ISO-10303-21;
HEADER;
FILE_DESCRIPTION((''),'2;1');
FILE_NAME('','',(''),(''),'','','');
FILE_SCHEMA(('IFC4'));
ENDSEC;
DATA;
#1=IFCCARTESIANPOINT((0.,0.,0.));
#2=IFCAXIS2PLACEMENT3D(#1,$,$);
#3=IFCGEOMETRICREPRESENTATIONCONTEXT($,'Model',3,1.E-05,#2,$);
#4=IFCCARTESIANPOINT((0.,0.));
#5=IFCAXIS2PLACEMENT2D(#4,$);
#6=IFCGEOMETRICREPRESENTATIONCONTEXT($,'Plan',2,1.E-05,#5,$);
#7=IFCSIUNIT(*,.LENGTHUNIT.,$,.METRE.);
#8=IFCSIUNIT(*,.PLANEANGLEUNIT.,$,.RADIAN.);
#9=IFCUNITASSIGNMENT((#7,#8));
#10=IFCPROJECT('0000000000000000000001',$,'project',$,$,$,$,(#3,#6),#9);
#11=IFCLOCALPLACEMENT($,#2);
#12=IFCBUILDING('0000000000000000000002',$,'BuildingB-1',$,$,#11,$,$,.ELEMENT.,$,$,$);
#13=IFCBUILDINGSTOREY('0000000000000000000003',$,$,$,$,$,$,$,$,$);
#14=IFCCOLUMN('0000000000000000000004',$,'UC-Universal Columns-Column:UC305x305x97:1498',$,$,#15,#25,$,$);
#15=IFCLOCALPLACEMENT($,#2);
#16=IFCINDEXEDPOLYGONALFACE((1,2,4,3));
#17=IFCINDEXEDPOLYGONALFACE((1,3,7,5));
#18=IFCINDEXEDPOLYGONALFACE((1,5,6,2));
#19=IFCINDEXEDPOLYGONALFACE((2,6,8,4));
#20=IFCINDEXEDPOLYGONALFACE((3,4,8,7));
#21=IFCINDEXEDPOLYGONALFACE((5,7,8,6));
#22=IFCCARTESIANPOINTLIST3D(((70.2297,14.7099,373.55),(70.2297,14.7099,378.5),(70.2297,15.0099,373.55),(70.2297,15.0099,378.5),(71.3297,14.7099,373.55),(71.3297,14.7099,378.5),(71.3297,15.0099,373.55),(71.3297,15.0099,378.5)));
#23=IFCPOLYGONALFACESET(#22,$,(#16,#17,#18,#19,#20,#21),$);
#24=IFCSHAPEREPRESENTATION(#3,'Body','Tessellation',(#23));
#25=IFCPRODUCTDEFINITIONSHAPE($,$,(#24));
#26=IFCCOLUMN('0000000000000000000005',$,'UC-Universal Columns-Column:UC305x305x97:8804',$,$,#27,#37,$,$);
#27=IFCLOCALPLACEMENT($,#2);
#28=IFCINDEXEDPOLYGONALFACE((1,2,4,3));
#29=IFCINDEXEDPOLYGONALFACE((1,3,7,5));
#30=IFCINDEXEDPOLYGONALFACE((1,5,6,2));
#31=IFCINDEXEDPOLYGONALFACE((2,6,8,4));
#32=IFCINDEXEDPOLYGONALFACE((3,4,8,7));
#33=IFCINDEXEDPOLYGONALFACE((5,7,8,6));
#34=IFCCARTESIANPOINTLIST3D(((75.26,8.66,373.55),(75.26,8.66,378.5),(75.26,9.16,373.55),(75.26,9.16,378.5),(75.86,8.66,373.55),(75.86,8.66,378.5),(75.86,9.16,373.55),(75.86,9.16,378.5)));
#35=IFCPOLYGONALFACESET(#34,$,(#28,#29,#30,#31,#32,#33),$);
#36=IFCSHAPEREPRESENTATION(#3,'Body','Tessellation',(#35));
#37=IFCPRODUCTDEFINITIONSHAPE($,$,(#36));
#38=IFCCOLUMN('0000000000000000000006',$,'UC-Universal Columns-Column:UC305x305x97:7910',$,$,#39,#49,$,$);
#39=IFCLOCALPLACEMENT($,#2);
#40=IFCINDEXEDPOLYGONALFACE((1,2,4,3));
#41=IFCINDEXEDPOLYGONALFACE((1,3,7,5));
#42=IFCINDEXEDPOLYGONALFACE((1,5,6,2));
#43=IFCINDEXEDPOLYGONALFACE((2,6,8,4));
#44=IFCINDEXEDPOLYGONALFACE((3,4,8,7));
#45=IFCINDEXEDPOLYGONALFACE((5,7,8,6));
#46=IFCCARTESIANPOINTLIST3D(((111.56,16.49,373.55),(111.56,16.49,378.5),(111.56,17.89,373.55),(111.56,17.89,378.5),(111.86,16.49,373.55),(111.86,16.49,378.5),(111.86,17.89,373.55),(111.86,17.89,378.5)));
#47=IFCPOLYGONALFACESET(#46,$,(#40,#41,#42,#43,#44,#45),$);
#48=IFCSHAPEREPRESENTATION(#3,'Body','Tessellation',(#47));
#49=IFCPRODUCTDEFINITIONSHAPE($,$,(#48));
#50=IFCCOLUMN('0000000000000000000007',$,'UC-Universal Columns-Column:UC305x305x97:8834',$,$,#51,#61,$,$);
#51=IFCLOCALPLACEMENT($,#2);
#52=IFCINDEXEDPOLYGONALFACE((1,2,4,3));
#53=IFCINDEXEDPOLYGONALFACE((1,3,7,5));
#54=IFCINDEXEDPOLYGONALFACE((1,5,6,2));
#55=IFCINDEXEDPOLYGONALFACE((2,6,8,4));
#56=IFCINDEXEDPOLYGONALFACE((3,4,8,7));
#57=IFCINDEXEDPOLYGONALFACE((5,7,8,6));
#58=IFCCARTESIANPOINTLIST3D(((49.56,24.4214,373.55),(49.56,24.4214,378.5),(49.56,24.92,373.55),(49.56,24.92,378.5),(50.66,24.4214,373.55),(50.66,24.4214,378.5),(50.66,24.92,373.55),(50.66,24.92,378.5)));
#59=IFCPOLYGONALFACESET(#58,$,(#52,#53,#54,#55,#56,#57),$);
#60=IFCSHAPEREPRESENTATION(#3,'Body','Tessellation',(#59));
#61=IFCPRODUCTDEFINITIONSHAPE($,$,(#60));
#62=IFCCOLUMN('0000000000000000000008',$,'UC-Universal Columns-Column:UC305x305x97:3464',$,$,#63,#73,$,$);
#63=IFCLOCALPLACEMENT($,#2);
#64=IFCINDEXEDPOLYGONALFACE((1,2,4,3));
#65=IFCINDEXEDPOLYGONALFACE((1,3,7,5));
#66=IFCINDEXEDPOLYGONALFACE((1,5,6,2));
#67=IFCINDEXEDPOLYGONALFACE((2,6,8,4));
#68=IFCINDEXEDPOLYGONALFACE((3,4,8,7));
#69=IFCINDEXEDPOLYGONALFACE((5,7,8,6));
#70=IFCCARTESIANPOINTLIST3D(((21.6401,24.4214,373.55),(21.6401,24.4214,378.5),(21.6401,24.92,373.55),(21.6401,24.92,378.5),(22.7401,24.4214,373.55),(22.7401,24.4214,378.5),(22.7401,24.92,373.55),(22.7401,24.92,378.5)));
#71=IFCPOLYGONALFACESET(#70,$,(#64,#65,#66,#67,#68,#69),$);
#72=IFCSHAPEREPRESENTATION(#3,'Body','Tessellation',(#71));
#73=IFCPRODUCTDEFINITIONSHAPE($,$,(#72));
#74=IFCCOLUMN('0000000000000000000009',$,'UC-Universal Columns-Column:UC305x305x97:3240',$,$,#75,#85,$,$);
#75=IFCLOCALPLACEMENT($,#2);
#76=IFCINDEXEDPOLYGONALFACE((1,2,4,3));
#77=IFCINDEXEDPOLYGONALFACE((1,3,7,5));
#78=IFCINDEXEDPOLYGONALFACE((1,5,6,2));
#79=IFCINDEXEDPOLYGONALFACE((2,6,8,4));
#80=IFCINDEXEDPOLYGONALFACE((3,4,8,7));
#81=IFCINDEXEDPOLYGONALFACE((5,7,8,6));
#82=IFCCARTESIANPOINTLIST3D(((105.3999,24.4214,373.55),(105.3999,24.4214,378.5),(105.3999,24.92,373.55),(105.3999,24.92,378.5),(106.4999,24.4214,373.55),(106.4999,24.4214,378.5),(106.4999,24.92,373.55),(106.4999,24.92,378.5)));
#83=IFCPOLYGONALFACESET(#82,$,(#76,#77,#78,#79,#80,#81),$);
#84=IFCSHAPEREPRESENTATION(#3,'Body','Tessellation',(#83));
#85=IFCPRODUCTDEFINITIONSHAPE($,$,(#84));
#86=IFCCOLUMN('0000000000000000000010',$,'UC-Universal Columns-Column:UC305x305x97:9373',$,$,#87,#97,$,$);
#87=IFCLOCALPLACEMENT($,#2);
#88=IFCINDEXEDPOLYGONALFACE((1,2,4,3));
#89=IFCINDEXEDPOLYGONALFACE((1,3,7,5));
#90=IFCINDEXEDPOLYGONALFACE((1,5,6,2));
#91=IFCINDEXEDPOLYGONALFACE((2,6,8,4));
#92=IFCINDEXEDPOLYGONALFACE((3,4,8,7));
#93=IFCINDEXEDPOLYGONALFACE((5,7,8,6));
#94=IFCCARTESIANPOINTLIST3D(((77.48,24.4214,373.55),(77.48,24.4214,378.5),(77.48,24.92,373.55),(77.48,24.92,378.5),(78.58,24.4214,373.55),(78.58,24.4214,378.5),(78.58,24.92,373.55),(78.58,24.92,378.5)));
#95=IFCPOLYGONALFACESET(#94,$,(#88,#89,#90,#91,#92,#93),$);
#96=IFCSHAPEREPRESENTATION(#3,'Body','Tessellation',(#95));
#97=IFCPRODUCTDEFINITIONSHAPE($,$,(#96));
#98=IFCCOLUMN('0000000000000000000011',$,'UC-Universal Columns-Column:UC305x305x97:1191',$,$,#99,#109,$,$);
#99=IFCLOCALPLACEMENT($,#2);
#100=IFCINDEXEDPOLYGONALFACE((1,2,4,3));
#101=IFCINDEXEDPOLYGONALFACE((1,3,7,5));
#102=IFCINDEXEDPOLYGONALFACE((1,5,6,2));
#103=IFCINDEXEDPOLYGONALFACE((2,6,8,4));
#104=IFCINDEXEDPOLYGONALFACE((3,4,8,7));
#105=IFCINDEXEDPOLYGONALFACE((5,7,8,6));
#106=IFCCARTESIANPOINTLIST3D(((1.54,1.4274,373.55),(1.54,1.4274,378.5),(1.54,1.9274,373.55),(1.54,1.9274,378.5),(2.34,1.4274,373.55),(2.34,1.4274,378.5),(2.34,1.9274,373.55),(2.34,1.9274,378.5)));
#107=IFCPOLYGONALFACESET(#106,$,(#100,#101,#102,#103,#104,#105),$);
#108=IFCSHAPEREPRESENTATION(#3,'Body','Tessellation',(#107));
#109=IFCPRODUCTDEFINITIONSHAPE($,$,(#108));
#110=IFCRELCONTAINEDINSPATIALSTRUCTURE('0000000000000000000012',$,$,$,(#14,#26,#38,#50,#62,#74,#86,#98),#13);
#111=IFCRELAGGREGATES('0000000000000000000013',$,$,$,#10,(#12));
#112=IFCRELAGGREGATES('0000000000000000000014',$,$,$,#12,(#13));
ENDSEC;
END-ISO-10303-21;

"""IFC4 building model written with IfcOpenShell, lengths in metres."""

from ifc_helpers import new_model, si_unit, origin, origin_2d, place, context, project, spatial, polyline, outline, extrude, element, save


model = new_model("IFC4")

# Units and contexts
model_context = context("Model", 3, precision=1e-05, world=origin())
plan_context = context("Plan", 2, precision=1e-05, world=origin_2d())
ifc_project = project(units=[si_unit("LENGTHUNIT", "METRE"), si_unit("PLANEANGLEUNIT", "RADIAN")], contexts=[model_context, plan_context])

# Building, storey
building_placement = place(None, origin())
building = spatial("IfcBuilding", under=ifc_project, at=building_placement, Name="BuildingB-1", CompositionType="ELEMENT")
storey = spatial("IfcBuildingStorey", under=building)

# Columns
element("IfcColumn", 1, inside=storey, Name="UC-Universal Columns-Column:UC305x305x97:1498", context=model_context, shape_type="SweptSolid", body=[
    extrude(outline(polyline([(70.2297, 15.0099, 378.5), (71.3297, 15.0099, 378.5), (71.3297, 14.7099, 378.5), (70.2297, 14.7099, 378.5), (70.2297, 15.0099, 378.5)])), None, (0.0, 0.0, -1.0), 4.95),
])
element("IfcColumn", 2, inside=storey, Name="UC-Universal Columns-Column:UC305x305x97:8804", context=model_context, shape_type="SweptSolid", body=[
    extrude(outline(polyline([(75.26, 8.66, 378.5), (75.86, 8.66, 378.5), (75.86, 9.16, 378.5), (75.26, 9.16, 378.5), (75.26, 8.66, 378.5)])), None, (0.0, 0.0, -1.0), 4.95),
])
element("IfcColumn", 3, inside=storey, Name="UC-Universal Columns-Column:UC305x305x97:7910", context=model_context, shape_type="SweptSolid", body=[
    extrude(outline(polyline([(111.86, 17.89, 378.5), (111.56, 17.89, 378.5), (111.56, 16.49, 378.5), (111.86, 16.49, 378.5), (111.86, 17.89, 378.5)])), None, (0.0, 0.0, -1.0), 4.95),
])
element("IfcColumn", 4, inside=storey, Name="UC-Universal Columns-Column:UC305x305x97:8834", context=model_context, shape_type="SweptSolid", body=[
    extrude(outline(polyline([(50.66, 24.4214, 378.5), (49.56, 24.4214, 378.5), (49.56, 24.92, 378.5), (50.66, 24.92, 378.5), (50.66, 24.4214, 378.5)])), None, (0.0, 0.0, -1.0), 4.95),
])
element("IfcColumn", 5, inside=storey, Name="UC-Universal Columns-Column:UC305x305x97:3464", context=model_context, shape_type="SweptSolid", body=[
    extrude(outline(polyline([(21.6401, 24.4214, 378.5), (22.7401, 24.4214, 378.5), (22.7401, 24.92, 378.5), (21.6401, 24.92, 378.5), (21.6401, 24.4214, 378.5)])), None, (0.0, 0.0, -1.0), 4.95),
])
element("IfcColumn", 6, inside=storey, Name="UC-Universal Columns-Column:UC305x305x97:3240", context=model_context, shape_type="SweptSolid", body=[
    extrude(outline(polyline([(106.4999, 24.4214, 378.5), (105.3999, 24.4214, 378.5), (105.3999, 24.92, 378.5), (106.4999, 24.92, 378.5), (106.4999, 24.4214, 378.5)])), None, (0.0, 0.0, -1.0), 4.95),
])
element("IfcColumn", 7, inside=storey, Name="UC-Universal Columns-Column:UC305x305x97:9373", context=model_context, shape_type="SweptSolid", body=[
    extrude(outline(polyline([(77.48, 24.4214, 378.5), (78.58, 24.4214, 378.5), (78.58, 24.92, 378.5), (77.48, 24.92, 378.5), (77.48, 24.4214, 378.5)])), None, (0.0, 0.0, -1.0), 4.95),
])
element("IfcColumn", 8, inside=storey, Name="UC-Universal Columns-Column:UC305x305x97:1191", context=model_context, shape_type="SweptSolid", body=[
    extrude(outline(polyline([(1.54, 1.4274, 378.5), (2.34, 1.4274, 378.5), (2.34, 1.9274, 378.5), (1.54, 1.9274, 378.5), (1.54, 1.4274, 378.5)])), None, (0.0, 0.0, -1.0), 4.95),
])

save(model, "model.ifc")
